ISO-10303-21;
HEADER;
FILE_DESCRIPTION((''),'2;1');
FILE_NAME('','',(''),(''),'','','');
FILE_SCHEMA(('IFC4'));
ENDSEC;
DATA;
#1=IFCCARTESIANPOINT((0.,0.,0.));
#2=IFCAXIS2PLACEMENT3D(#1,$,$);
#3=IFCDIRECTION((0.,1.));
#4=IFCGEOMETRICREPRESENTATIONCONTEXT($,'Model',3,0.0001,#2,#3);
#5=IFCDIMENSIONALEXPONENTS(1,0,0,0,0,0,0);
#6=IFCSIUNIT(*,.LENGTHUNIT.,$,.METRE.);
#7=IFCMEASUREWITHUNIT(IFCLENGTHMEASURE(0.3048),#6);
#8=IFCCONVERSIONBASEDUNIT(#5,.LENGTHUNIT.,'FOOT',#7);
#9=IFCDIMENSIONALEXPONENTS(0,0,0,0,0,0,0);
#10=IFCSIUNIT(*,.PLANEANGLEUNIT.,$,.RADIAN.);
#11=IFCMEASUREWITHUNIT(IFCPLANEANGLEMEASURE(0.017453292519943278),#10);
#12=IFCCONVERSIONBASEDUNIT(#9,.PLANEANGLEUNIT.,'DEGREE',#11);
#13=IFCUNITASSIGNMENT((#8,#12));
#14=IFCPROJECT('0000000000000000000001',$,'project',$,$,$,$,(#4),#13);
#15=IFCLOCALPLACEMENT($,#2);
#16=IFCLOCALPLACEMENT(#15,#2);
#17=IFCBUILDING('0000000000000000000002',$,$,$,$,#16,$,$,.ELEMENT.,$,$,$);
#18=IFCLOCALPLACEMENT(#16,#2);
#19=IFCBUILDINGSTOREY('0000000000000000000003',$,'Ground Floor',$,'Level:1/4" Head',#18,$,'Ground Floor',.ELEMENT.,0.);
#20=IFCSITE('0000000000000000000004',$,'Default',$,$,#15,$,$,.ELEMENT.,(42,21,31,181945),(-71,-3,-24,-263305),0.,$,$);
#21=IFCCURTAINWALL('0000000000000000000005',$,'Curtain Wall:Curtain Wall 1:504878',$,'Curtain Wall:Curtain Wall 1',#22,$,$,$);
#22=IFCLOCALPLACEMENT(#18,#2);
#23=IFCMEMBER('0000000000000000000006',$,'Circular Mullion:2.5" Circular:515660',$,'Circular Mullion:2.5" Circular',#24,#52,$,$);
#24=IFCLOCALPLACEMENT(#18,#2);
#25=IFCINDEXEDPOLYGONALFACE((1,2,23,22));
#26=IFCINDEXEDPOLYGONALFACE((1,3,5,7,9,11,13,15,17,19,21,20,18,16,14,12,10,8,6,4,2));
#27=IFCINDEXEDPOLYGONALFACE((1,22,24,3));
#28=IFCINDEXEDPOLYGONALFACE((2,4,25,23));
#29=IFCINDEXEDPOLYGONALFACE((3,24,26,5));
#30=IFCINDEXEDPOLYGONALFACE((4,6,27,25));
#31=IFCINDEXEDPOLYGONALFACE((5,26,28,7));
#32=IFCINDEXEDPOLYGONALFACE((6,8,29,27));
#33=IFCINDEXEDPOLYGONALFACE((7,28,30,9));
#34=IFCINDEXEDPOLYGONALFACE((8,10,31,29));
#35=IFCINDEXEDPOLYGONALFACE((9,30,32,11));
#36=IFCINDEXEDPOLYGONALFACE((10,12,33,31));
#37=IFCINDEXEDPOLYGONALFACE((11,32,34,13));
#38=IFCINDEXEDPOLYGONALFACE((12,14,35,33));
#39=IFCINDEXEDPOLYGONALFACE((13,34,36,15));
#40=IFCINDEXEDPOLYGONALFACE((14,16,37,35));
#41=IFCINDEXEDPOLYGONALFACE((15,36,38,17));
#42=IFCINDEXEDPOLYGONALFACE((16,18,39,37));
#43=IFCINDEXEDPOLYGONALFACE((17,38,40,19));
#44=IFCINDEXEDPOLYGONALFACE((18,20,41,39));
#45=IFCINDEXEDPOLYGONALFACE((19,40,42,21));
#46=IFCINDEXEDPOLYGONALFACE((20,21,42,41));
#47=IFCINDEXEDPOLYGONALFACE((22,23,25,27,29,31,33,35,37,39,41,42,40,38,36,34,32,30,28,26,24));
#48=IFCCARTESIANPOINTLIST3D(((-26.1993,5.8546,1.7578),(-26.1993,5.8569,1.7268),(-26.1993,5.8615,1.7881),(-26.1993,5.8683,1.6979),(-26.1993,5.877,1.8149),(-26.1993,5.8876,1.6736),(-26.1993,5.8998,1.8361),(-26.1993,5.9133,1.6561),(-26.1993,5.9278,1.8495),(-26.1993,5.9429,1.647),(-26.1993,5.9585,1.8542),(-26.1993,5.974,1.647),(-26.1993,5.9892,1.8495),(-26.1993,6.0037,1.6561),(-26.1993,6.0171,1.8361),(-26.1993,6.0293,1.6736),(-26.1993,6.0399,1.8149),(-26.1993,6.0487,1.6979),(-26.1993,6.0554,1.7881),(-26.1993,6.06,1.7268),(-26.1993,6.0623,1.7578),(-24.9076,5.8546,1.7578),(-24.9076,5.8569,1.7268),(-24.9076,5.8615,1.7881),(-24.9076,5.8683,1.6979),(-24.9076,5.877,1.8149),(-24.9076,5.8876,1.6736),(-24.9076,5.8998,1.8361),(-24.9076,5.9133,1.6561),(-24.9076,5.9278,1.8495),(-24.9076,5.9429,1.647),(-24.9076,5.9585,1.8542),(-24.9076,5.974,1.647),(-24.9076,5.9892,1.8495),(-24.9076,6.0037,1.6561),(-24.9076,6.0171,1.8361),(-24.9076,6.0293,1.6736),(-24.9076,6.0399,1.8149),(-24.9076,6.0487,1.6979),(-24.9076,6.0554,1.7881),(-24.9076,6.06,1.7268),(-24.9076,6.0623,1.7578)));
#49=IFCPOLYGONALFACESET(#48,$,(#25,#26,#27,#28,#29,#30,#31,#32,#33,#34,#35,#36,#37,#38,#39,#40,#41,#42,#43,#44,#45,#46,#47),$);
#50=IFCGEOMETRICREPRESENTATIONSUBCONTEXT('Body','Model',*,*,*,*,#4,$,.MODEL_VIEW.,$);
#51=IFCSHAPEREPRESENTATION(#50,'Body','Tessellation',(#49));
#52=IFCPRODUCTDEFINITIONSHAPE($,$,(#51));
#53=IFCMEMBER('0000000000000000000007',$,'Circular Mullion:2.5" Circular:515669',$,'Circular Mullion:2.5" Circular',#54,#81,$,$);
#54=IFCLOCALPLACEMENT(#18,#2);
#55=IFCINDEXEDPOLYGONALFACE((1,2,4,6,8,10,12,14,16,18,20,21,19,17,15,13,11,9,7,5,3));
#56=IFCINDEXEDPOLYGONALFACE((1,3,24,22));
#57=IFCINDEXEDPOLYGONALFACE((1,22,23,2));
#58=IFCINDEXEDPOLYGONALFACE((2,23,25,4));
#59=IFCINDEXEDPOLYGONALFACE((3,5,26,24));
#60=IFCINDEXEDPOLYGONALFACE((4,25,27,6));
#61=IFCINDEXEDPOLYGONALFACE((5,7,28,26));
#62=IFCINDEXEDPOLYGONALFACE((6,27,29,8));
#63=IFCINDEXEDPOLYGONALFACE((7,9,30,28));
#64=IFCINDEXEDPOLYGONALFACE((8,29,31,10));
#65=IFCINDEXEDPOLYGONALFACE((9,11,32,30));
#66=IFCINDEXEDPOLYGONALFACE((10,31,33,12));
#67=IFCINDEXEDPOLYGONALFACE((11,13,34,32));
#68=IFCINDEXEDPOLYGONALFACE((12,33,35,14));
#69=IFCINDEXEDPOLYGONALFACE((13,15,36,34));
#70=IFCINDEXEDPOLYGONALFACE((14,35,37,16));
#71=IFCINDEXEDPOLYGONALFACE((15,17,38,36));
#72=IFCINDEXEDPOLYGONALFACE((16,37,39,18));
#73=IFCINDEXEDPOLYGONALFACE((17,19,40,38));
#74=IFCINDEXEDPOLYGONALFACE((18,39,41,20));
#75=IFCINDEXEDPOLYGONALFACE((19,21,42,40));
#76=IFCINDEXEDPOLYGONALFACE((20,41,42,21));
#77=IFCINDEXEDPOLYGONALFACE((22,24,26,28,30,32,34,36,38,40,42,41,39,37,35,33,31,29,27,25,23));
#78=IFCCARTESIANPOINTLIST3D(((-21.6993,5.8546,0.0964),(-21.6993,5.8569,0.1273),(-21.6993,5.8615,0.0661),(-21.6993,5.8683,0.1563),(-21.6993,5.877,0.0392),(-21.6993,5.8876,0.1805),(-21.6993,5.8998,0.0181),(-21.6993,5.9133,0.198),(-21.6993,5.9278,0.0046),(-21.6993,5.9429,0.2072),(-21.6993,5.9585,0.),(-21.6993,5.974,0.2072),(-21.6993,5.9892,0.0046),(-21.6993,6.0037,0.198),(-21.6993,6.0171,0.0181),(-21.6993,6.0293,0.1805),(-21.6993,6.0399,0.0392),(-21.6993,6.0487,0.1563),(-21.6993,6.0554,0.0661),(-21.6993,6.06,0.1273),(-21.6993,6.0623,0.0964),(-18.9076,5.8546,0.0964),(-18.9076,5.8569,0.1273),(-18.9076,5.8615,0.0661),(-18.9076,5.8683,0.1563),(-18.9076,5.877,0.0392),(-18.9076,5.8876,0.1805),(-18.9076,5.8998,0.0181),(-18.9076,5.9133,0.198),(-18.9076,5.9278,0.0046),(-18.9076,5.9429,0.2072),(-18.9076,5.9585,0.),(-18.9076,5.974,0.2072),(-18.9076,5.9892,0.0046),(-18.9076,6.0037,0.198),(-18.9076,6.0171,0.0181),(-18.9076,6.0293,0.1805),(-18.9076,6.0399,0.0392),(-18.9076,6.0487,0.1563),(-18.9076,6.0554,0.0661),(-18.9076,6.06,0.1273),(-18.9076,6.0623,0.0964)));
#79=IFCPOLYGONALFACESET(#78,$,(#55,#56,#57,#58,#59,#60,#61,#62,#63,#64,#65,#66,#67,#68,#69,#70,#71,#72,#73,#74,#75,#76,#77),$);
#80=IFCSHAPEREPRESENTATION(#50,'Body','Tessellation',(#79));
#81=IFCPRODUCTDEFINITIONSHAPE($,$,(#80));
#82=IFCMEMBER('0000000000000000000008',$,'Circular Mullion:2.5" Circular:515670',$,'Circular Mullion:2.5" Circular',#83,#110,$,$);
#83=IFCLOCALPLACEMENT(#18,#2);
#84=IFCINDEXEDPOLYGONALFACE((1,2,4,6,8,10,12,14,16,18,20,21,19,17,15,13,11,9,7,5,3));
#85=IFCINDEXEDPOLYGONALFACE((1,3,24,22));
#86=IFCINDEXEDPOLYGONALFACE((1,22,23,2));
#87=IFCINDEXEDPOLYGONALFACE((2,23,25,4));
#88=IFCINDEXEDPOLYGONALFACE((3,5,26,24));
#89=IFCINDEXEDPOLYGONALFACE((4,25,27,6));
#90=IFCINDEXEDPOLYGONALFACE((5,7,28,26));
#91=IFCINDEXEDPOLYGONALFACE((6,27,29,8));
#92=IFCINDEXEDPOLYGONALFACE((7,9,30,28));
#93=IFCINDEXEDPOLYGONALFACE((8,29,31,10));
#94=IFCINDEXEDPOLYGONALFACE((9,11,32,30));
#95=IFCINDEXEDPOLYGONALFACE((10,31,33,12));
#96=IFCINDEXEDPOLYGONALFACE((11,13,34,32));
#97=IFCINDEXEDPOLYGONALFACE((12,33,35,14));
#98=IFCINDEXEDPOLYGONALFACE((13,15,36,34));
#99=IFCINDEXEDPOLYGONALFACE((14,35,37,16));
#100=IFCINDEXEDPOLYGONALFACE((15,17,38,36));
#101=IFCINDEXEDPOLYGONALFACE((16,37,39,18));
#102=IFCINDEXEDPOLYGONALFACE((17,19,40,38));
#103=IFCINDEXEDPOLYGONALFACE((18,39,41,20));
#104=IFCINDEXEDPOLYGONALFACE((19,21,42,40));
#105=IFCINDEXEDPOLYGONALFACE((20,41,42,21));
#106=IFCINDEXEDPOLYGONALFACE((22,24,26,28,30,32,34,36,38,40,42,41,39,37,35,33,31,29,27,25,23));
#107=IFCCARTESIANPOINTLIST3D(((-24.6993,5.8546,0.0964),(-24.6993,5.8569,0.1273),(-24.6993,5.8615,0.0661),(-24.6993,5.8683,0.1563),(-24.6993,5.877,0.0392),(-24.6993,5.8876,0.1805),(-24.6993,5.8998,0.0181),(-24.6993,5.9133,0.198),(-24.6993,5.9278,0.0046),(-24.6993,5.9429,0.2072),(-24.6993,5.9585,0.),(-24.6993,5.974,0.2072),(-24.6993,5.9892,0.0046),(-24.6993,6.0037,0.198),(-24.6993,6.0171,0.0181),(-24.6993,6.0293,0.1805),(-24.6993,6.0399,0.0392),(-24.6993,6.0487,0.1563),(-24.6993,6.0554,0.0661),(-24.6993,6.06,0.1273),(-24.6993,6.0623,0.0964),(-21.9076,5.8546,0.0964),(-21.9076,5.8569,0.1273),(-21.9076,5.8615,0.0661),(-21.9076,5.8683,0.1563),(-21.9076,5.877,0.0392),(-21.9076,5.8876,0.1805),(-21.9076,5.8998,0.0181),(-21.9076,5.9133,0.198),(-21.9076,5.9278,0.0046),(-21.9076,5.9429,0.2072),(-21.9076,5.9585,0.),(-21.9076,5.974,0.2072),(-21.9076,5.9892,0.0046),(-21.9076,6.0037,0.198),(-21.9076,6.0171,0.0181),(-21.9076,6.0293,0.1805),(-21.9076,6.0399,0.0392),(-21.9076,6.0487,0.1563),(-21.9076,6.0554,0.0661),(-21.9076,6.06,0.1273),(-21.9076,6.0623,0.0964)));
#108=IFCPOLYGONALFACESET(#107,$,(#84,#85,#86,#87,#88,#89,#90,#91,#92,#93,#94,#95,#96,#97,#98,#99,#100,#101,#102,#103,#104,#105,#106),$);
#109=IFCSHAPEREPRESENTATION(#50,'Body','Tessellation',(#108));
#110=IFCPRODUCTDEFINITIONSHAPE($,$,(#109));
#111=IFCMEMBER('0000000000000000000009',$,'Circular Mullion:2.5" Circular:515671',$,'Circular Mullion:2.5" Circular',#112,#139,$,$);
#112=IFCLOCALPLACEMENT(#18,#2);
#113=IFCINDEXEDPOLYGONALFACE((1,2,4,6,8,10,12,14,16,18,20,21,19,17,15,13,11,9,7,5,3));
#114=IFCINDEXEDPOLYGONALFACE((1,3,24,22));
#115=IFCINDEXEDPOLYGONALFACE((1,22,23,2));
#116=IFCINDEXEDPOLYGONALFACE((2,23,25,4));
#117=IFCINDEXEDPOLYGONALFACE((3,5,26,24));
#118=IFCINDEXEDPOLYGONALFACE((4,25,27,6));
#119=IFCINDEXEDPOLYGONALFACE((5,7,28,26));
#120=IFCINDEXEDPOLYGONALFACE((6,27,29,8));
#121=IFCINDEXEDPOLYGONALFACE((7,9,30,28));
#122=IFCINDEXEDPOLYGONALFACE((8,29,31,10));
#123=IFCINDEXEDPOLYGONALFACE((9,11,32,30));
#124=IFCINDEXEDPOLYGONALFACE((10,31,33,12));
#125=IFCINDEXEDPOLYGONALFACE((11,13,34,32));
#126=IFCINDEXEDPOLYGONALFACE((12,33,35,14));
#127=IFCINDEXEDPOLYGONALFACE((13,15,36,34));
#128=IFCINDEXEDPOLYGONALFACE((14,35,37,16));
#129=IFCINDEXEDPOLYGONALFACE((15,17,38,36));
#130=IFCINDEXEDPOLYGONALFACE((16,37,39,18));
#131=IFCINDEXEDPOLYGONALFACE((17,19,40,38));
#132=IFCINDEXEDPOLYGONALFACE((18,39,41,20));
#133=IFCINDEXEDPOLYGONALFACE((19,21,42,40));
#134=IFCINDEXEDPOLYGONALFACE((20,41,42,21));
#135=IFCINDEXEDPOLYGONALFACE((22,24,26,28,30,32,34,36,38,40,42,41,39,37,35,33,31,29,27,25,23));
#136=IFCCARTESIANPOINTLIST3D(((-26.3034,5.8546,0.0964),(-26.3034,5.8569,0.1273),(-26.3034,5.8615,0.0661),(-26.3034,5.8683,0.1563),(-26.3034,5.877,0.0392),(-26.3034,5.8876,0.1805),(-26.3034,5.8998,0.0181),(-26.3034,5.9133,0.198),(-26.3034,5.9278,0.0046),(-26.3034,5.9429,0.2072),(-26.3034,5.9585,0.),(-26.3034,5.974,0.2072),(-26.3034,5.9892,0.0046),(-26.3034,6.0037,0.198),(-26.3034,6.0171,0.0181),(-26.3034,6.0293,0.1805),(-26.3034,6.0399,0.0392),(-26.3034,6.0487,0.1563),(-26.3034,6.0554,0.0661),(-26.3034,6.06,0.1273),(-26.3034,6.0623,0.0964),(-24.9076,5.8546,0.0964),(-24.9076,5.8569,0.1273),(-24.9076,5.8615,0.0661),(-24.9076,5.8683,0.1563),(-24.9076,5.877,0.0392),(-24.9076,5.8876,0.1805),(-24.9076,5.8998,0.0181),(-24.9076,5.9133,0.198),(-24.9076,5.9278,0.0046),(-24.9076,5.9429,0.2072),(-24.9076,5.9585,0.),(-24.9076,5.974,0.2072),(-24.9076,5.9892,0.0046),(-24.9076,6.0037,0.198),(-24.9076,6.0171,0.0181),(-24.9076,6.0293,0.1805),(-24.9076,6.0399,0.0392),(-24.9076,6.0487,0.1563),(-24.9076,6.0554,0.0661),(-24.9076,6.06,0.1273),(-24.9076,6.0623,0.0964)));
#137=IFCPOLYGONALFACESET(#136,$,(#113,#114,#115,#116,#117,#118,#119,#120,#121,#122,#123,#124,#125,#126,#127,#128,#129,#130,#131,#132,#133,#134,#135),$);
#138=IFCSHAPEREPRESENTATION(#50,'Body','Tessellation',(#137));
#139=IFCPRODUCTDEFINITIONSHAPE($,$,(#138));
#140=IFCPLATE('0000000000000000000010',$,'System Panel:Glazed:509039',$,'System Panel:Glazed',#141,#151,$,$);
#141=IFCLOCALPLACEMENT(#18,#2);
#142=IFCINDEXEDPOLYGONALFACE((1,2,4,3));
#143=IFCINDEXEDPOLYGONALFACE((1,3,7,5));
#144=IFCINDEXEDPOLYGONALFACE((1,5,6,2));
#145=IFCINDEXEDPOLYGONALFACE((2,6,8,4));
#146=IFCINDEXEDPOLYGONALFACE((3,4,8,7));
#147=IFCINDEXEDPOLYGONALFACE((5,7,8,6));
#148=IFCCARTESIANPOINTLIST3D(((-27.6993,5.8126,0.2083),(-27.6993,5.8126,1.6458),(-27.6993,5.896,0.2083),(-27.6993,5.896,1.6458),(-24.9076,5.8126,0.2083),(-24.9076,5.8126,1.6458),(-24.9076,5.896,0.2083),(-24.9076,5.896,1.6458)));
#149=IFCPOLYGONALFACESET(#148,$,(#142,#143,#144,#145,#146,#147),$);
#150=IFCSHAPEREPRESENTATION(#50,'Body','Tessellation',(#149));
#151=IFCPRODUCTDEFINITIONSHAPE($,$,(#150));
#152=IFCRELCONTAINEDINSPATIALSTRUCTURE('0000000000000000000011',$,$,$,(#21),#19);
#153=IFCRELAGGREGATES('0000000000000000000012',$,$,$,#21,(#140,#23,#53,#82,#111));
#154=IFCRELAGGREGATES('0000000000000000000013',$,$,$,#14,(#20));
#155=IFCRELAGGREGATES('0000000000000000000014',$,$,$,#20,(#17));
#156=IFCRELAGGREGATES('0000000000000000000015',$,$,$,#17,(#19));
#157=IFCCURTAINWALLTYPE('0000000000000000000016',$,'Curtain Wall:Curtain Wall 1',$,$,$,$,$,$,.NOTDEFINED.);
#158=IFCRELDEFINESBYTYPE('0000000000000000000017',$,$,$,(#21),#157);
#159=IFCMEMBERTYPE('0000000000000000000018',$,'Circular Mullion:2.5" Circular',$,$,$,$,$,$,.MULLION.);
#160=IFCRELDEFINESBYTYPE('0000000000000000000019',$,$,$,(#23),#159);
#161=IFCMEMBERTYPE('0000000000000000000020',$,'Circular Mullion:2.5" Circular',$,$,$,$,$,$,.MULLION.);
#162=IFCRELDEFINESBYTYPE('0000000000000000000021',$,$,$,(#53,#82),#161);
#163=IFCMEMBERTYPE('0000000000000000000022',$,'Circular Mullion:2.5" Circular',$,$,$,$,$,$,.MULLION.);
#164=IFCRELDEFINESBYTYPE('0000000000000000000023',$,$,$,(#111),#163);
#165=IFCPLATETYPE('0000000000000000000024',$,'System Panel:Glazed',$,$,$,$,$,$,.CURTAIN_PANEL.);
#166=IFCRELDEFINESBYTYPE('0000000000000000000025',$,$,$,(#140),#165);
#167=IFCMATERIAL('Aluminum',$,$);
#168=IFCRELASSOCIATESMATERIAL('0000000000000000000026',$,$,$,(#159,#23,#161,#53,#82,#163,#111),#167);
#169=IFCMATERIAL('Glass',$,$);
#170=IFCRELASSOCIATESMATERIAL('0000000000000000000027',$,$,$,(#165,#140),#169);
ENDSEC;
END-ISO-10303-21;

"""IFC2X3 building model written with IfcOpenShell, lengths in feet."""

from ifc_helpers import new_model, entity, si_unit, converted_unit, direction, frame, frame_2d, origin, place, context, subcontext, project, spatial, rectangle, circle, extrude, source, transform, mapped, material, type_object, type_shapes, element, aggregate, save


model = new_model("IFC2X3")

# Units and contexts
model_context = context("Model", 3, precision=0.0001, world=origin(), true_north=direction((0.0, 1.0)))
body_context = subcontext(model_context, "Body", "Model", "MODEL_VIEW")
ifc_project = project(units=[converted_unit("LENGTHUNIT", "FOOT", entity("IfcLengthMeasure", 0.3048), si_unit("LENGTHUNIT", "METRE"), dimensions=[1, 0, 0, 0, 0, 0, 0]), converted_unit("PLANEANGLEUNIT", "DEGREE", entity("IfcPlaneAngleMeasure", 0.017453292519943278), si_unit("PLANEANGLEUNIT", "RADIAN"), dimensions=[0, 0, 0, 0, 0, 0, 0])], contexts=[model_context])

# Site, building, storey
site_placement = place(None, origin())
site = spatial("IfcSite", under=ifc_project, at=site_placement, Name="Default", CompositionType="ELEMENT", RefLatitude=(42, 21, 31, 181945), RefLongitude=(-71, -3, -24, -263305), RefElevation=0.0)
building_placement = place(site_placement, origin())
building = spatial("IfcBuilding", under=site, at=building_placement, CompositionType="ELEMENT")
storey_placement = place(building_placement, origin())
storey = spatial("IfcBuildingStorey", under=building, at=storey_placement, Name="Ground Floor", ObjectType="Level:1/4\" Head", LongName="Ground Floor", CompositionType="ELEMENT", Elevation=0.0)

# Curtain wall, members, plate
curtain_wall_type = type_object("IfcCurtainWallType", Name="Curtain Wall:Curtain Wall 1", PredefinedType="NOTDEFINED")
curtain_wall_placement = place(storey_placement, origin())
curtain_wall = element("IfcCurtainWall", 1, at=curtain_wall_placement, inside=storey, type_object=curtain_wall_type, Name="Curtain Wall:Curtain Wall 1:504878", ObjectType="Curtain Wall:Curtain Wall 1")
ifc_material_1 = material(Name="Aluminum")
member_type_1 = type_object("IfcMemberType", Name="Circular Mullion:2.5\" Circular", PredefinedType="MULLION", material=ifc_material_1)
shared_shape_1 = source(origin(), body_context, "Body", "SweptSolid", [
    extrude(circle(Radius=0.1042, at=frame_2d((0.0, 0.0), x_axis=(1.0, 0.0))), frame((0.0, 0.0, -1.2917)), (0.0, 0.0, 1.0), 1.2917),
])
type_shapes(member_type_1, [shared_shape_1])
member_1_placement = place(curtain_wall_placement, frame((-26.1993, 5.9585, 1.75), z_axis=(-1.0, 0.0, 0.0), x_axis=(0.0, 0.0, 1.0)))
member_1 = element("IfcMember", 2, at=member_1_placement, type_object=member_type_1, material=ifc_material_1, Name="Circular Mullion:2.5\" Circular:515660", ObjectType="Circular Mullion:2.5\" Circular", context=body_context, shape_type="MappedRepresentation", body=[
    mapped(shared_shape_1, transform((0.0, 0.0, 0.0), scale=1.0)),
])
member_type_2 = type_object("IfcMemberType", Name="Circular Mullion:2.5\" Circular", PredefinedType="MULLION", material=ifc_material_1)
shared_shape_2 = source(origin(), body_context, "Body", "SweptSolid", [
    extrude(circle(Radius=0.1042, at=frame_2d((0.0, 0.0), x_axis=(1.0, 0.0))), frame((-0.1042, 0.0, -2.7917)), (0.0, 0.0, 1.0), 2.7917),
])
type_shapes(member_type_2, [shared_shape_2])
member_2_placement = place(curtain_wall_placement, frame((-18.9076, 5.9585, 0.0), z_axis=(1.0, 0.0, 0.0), x_axis=(0.0, 0.0, -1.0)))
member_2 = element("IfcMember", 3, at=member_2_placement, type_object=member_type_2, material=ifc_material_1, Name="Circular Mullion:2.5\" Circular:515669", ObjectType="Circular Mullion:2.5\" Circular", context=body_context, shape_type="MappedRepresentation", body=[
    mapped(shared_shape_2, transform((0.0, 0.0, 0.0), scale=1.0)),
])
member_3_placement = place(curtain_wall_placement, frame((-21.9076, 5.9585, 0.0), z_axis=(1.0, 0.0, 0.0), x_axis=(0.0, 0.0, -1.0)))
member_3 = element("IfcMember", 4, at=member_3_placement, type_object=member_type_2, material=ifc_material_1, Name="Circular Mullion:2.5\" Circular:515670", ObjectType="Circular Mullion:2.5\" Circular", context=body_context, shape_type="MappedRepresentation", body=[
    mapped(shared_shape_2, transform((0.0, 0.0, 0.0), scale=1.0)),
])
member_type_3 = type_object("IfcMemberType", Name="Circular Mullion:2.5\" Circular", PredefinedType="MULLION", material=ifc_material_1)
shared_shape_3 = source(origin(), body_context, "Body", "SweptSolid", [
    extrude(circle(Radius=0.1042, at=frame_2d((0.0, 0.0), x_axis=(1.0, 0.0))), frame((-0.1042, 0.0, -1.3958)), (0.0, 0.0, 1.0), 1.3958),
])
type_shapes(member_type_3, [shared_shape_3])
member_4_placement = place(curtain_wall_placement, frame((-24.9076, 5.9585, 0.0), z_axis=(1.0, 0.0, 0.0), x_axis=(0.0, 0.0, -1.0)))
member_4 = element("IfcMember", 5, at=member_4_placement, type_object=member_type_3, material=ifc_material_1, Name="Circular Mullion:2.5\" Circular:515671", ObjectType="Circular Mullion:2.5\" Circular", context=body_context, shape_type="MappedRepresentation", body=[
    mapped(shared_shape_3, transform((0.0, 0.0, 0.0), scale=1.0)),
])
ifc_material_2 = material(Name="Glass")
plate_type_1 = type_object("IfcPlateType", Name="System Panel:Glazed", PredefinedType="CURTAIN_PANEL", material=ifc_material_2)
shared_shape_4 = source(origin(), body_context, "Body", "SweptSolid", [
    extrude(rectangle(XDim=1.4375, YDim=2.7917, at=frame_2d((0.0, 0.0), x_axis=(1.0, 0.0))), frame((0.0, 0.0625, 0.7188), z_axis=(0.0, 1.0, 0.0), x_axis=(0.0, 0.0, 1.0)), (0.0, 0.0, 1.0), 0.0833),
])
type_shapes(plate_type_1, [shared_shape_4])
plate_1_placement = place(curtain_wall_placement, frame((-26.3034, 5.9585, 0.2083), z_axis=(0.0, 0.0, 1.0), x_axis=(-1.0, 0.0, 0.0)))
plate_1 = element("IfcPlate", 6, at=plate_1_placement, type_object=plate_type_1, material=ifc_material_2, Name="System Panel:Glazed:509039", ObjectType="System Panel:Glazed", context=body_context, shape_type="MappedRepresentation", body=[
    mapped(shared_shape_4, transform((0.0, 0.0, 0.0), scale=1.0)),
])
aggregate(curtain_wall, [plate_1, member_1, member_2, member_3, member_4])

save(model, "model.ifc")
